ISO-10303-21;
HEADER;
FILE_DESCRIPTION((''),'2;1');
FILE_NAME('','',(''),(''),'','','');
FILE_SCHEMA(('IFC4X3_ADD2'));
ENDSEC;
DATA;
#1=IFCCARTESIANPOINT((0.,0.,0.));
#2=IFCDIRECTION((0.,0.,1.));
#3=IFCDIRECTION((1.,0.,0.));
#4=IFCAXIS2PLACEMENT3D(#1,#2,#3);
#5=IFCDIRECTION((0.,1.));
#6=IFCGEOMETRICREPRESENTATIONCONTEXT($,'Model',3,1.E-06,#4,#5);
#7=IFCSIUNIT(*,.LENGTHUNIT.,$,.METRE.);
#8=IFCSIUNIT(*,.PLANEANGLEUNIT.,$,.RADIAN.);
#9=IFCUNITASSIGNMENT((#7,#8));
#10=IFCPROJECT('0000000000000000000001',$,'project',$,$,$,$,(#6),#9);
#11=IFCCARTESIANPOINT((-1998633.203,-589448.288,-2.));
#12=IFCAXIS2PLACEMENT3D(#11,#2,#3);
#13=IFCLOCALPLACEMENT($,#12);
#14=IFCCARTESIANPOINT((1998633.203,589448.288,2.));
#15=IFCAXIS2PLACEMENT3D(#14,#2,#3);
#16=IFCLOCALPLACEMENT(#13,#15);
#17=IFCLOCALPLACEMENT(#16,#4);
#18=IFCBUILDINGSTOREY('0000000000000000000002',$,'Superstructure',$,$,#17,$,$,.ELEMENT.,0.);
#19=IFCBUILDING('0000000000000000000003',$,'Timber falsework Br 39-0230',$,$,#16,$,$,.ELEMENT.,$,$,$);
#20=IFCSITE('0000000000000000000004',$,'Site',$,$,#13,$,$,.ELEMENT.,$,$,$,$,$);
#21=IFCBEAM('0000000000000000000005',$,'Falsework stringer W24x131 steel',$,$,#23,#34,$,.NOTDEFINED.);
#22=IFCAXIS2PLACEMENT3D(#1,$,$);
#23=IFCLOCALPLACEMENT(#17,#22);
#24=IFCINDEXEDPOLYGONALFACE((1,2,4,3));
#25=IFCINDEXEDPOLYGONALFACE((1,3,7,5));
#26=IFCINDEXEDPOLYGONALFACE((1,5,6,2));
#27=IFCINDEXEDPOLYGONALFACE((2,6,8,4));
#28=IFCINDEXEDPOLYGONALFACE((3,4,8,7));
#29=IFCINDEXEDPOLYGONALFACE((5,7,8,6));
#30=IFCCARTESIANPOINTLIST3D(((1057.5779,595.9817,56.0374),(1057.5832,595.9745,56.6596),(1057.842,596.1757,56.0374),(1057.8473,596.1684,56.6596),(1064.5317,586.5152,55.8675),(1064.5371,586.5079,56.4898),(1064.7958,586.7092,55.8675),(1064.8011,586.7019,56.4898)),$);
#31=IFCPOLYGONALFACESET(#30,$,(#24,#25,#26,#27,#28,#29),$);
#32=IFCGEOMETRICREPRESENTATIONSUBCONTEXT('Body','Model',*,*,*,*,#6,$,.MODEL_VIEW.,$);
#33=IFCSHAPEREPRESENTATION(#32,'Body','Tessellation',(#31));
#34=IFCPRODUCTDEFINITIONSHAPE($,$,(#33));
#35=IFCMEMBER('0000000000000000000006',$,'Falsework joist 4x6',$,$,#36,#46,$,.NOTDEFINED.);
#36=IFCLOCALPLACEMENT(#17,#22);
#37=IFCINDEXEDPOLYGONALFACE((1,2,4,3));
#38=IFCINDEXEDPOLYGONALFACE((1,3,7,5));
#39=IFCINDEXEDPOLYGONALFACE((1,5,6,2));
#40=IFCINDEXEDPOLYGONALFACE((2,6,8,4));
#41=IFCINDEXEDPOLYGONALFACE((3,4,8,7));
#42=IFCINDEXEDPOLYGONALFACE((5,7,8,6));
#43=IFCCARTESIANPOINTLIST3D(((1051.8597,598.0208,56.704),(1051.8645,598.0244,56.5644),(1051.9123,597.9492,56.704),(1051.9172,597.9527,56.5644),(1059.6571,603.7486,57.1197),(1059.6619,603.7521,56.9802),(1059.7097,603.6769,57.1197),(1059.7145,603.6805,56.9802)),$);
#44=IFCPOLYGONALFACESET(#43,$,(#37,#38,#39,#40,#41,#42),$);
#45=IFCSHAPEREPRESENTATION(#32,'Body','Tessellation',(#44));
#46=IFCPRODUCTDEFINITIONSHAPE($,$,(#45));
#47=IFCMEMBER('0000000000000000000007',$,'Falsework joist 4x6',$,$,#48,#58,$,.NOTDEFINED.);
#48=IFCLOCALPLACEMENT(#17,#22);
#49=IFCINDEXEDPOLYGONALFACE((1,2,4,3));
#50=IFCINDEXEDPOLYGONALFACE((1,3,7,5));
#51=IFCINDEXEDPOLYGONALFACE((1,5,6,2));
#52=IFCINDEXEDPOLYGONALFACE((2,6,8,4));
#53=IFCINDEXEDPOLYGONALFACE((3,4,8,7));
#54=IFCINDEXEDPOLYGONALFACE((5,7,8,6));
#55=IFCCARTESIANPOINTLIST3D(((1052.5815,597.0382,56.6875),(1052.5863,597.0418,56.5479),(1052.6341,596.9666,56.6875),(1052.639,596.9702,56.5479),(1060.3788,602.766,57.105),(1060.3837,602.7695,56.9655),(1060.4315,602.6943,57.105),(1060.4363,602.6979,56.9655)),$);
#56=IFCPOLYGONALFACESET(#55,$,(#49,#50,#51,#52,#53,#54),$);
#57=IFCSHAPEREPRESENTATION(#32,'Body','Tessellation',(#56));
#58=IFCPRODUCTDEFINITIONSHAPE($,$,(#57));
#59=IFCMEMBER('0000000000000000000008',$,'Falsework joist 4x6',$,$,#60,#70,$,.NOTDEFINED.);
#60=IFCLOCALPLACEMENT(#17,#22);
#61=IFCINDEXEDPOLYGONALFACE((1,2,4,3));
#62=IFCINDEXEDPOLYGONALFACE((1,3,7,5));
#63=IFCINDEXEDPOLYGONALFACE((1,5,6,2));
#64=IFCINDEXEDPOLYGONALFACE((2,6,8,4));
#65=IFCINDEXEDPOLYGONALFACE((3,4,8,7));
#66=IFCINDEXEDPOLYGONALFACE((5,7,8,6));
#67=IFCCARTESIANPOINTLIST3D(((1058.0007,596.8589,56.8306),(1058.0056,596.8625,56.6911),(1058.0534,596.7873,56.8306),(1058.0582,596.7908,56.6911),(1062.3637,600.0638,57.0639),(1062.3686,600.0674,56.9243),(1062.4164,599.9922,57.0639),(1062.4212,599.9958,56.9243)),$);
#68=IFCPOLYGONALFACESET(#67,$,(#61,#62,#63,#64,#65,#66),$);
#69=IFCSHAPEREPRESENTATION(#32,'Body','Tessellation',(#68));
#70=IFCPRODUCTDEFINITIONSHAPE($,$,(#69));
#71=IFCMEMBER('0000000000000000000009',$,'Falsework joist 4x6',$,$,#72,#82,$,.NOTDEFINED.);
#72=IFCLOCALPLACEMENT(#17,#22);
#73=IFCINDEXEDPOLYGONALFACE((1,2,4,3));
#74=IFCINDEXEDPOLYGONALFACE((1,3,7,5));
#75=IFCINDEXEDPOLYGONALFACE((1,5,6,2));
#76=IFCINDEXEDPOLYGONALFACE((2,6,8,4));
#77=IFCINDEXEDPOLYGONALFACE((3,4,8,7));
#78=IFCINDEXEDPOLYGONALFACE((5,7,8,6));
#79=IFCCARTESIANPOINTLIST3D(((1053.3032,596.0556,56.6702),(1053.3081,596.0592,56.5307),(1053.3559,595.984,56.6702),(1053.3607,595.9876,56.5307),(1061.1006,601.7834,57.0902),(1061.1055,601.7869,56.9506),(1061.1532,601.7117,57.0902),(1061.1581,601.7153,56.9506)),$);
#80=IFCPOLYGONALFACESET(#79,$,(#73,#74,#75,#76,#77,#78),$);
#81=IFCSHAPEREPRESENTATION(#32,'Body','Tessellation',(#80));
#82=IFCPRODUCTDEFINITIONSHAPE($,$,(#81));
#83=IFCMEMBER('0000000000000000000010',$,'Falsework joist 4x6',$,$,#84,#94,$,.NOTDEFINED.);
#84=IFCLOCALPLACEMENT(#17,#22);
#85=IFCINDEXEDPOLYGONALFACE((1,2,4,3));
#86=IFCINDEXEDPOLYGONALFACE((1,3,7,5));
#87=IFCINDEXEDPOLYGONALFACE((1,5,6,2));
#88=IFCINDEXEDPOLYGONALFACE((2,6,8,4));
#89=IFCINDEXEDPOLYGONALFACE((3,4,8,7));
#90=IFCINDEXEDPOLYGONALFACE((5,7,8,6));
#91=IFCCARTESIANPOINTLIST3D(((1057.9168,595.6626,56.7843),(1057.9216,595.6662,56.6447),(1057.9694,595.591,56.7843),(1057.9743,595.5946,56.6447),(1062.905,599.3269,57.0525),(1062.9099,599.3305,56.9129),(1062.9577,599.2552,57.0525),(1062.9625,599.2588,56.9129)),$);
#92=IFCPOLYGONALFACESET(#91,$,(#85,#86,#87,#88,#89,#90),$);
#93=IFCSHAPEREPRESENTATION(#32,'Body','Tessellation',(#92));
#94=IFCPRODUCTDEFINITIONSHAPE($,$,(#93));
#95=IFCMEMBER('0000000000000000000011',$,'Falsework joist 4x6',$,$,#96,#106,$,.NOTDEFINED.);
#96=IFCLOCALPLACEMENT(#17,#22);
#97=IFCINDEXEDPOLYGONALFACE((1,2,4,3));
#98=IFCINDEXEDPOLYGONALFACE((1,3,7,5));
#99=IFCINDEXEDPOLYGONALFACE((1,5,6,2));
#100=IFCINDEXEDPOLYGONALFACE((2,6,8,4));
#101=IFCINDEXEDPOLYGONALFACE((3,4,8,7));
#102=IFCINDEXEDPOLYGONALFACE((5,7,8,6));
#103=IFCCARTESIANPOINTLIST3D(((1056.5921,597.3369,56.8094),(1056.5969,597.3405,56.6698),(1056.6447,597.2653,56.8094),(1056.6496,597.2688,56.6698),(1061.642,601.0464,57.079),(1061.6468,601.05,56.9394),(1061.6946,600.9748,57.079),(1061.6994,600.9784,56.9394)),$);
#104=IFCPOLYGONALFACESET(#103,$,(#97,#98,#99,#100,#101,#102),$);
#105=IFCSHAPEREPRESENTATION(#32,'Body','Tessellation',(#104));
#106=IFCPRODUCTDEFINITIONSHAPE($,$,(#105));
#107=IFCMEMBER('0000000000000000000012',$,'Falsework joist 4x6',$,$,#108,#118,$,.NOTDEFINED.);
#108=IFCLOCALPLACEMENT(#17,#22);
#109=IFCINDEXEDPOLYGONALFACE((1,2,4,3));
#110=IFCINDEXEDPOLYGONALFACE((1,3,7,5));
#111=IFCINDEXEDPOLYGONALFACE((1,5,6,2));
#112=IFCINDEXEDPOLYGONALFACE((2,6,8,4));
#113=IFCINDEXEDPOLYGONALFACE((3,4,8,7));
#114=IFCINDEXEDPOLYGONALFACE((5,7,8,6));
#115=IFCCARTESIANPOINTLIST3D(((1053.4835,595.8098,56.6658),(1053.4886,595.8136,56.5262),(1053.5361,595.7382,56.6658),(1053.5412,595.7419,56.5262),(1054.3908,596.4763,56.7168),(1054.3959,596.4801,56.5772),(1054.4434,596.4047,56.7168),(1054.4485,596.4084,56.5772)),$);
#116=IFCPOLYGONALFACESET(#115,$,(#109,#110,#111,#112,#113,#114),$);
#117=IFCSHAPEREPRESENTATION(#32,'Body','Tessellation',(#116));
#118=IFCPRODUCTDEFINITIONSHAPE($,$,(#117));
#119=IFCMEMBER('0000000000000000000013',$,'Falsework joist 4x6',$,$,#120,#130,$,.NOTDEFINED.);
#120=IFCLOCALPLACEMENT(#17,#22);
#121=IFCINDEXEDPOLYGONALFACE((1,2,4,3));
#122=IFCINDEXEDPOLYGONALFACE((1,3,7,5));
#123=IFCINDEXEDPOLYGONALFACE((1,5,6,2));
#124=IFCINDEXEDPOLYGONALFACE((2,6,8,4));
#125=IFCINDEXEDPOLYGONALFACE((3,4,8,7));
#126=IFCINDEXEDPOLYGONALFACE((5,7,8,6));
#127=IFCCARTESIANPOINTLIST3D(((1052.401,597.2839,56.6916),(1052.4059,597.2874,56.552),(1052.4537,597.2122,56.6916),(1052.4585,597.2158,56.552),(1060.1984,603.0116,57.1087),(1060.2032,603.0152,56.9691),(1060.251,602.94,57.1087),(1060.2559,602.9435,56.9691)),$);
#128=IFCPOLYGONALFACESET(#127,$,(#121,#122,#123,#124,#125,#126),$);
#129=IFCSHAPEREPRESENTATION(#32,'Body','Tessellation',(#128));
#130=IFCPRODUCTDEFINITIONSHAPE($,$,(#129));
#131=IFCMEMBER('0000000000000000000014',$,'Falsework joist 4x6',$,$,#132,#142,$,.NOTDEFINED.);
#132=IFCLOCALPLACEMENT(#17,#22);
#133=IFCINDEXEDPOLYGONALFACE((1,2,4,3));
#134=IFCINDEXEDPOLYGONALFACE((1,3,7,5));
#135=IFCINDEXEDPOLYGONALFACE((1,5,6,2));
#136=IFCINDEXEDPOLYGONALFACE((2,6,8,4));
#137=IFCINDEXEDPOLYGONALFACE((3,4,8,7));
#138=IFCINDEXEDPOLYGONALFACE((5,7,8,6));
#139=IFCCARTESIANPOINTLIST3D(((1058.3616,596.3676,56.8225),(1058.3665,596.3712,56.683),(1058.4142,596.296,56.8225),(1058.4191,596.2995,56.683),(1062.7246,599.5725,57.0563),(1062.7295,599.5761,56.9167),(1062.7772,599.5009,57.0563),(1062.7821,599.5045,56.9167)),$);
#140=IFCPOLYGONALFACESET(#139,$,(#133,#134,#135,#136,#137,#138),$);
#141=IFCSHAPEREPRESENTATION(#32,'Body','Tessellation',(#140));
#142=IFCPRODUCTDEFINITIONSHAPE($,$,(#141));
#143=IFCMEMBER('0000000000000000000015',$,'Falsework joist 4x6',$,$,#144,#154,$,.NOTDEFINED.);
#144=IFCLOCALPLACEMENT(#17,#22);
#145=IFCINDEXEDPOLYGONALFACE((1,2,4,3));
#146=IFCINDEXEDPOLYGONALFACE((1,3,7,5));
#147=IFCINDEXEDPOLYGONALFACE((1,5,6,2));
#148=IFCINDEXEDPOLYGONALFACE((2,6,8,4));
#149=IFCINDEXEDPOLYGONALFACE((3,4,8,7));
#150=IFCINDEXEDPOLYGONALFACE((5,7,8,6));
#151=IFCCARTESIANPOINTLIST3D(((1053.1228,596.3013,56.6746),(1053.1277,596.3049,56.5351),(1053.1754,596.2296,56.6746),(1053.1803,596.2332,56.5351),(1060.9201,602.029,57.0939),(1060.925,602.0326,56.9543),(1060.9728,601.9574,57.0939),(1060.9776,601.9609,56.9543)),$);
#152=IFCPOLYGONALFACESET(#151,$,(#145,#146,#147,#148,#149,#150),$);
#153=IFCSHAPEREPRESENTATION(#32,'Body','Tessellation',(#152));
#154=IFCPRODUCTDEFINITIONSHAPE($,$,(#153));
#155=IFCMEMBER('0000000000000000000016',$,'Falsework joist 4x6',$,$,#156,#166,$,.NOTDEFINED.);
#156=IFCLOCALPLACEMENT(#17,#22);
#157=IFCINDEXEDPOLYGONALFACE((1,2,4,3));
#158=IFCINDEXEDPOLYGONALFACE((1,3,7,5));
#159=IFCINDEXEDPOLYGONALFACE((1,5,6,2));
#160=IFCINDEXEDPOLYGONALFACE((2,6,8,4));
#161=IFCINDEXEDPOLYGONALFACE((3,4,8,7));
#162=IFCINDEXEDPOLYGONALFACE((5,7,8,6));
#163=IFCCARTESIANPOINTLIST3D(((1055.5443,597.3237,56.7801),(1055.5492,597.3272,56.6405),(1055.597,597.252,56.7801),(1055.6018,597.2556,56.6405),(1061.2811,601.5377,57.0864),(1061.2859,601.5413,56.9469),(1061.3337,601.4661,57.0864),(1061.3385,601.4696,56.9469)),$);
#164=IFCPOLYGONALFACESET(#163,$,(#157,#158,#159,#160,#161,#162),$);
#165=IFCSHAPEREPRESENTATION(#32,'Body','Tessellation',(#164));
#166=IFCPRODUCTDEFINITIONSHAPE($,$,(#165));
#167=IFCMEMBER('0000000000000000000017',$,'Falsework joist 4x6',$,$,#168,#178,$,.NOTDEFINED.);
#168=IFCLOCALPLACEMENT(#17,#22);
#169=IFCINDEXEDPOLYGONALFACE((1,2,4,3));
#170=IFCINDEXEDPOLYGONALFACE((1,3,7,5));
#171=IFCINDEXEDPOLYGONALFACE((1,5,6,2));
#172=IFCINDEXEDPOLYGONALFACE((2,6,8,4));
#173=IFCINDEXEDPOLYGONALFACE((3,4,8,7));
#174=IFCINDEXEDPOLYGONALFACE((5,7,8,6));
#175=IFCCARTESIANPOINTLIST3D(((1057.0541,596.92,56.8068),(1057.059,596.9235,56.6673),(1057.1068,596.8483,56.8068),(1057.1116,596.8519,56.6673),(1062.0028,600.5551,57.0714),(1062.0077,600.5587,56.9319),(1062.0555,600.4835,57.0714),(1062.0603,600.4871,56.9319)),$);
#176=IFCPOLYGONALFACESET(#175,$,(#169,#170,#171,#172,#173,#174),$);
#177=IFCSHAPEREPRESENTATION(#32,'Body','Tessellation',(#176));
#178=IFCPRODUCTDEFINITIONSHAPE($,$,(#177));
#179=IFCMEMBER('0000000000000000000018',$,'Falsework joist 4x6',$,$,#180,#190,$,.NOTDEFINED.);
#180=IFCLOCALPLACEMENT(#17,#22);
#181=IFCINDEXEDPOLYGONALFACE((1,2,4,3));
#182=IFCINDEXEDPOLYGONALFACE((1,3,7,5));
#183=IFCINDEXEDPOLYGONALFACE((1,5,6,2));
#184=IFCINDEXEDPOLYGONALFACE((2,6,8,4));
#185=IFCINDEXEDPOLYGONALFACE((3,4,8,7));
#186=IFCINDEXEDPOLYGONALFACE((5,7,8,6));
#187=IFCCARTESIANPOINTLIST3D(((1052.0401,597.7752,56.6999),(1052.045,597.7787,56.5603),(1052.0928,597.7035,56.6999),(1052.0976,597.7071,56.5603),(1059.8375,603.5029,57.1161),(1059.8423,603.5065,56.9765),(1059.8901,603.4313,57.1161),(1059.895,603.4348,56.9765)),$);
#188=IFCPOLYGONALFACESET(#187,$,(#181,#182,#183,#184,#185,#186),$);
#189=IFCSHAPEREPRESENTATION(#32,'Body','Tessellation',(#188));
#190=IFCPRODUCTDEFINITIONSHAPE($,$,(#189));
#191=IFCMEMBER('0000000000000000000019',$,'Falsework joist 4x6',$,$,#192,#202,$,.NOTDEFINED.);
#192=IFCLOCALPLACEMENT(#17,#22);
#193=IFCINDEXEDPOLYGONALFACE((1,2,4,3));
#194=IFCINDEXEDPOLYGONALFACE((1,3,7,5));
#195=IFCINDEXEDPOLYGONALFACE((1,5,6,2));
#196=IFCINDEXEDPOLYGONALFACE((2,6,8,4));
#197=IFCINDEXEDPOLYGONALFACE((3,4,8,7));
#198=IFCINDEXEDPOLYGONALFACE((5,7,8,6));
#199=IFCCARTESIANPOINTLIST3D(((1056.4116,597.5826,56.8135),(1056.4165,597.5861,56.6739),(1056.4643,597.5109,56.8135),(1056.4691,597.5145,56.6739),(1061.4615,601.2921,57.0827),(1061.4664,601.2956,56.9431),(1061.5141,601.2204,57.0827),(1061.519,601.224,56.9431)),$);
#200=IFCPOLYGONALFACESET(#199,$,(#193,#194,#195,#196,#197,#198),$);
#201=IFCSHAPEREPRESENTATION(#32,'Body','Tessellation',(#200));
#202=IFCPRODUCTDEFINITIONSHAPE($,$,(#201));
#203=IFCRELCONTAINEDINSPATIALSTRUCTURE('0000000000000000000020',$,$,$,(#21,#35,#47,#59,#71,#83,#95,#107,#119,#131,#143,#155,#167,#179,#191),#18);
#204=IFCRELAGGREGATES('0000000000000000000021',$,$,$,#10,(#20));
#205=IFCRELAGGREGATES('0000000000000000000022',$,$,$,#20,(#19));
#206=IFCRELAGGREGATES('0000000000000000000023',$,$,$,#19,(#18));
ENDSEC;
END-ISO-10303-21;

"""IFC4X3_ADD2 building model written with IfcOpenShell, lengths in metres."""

from ifc_helpers import new_model, si_unit, direction, frame, frame_2d, origin, origin_with_axes, place, context, subcontext, project, spatial, rectangle, extrude, element, save


model = new_model("IFC4X3_ADD2")

# Units and contexts
model_context = context("Model", 3, precision=1e-06, world=origin_with_axes(), true_north=direction((0.0, 1.0)))
body_context = subcontext(model_context, "Body", "Model", "MODEL_VIEW")
ifc_project = project(units=[si_unit("LENGTHUNIT", "METRE"), si_unit("PLANEANGLEUNIT", "RADIAN")], contexts=[model_context])

# Site, building, storey
site_placement = place(None, frame((-1998633.203, -589448.288, -2.0), z_axis=(0.0, 0.0, 1.0), x_axis=(1.0, 0.0, 0.0)))
site = spatial("IfcSite", under=ifc_project, at=site_placement, Name="Site", CompositionType="ELEMENT")
building_placement = place(site_placement, frame((1998633.203, 589448.288, 2.0), z_axis=(0.0, 0.0, 1.0), x_axis=(1.0, 0.0, 0.0)))
building = spatial("IfcBuilding", under=site, at=building_placement, Name="Timber falsework Br 39-0230", CompositionType="ELEMENT")
storey_placement = place(building_placement, origin_with_axes())
storey = spatial("IfcBuildingStorey", under=building, at=storey_placement, Name="Superstructure", CompositionType="ELEMENT", Elevation=0.0)

# Beam
beam_placement = place(storey_placement, frame((1057.7099, 596.0787, 56.0374), z_axis=(0.591951, -0.805844, -0.01446), x_axis=(0.805928, 0.592013, 0.0)))
element("IfcBeam", 1, at=beam_placement, inside=storey, Name="Falsework stringer W24x131 steel", PredefinedType="NOTDEFINED", context=body_context, shape_type="SweptSolid", body=[
    extrude(rectangle(XDim=0.3277, YDim=0.6223, at=frame_2d((0.0, 0.3111))), origin(), (0.0, 0.0, 1.0), 11.7473),
])

# Members
member_1_placement = place(storey_placement, frame((1051.8909, 597.9886, 56.5644), z_axis=(0.805185, 0.591467, 0.042932), x_axis=(-0.592013, 0.805928, 0.0)))
element("IfcMember", 2, at=member_1_placement, inside=storey, Name="Falsework joist 4x6", PredefinedType="NOTDEFINED", context=body_context, shape_type="SweptSolid", body=[
    extrude(rectangle(XDim=0.0889, YDim=0.1397, at=frame_2d((0.0, 0.0698))), origin(), (0.0, 0.0, 1.0), 9.6839),
])
member_2_placement = place(storey_placement, frame((1052.6126, 597.006, 56.5479), z_axis=(0.805179, 0.591463, 0.043119), x_axis=(-0.592013, 0.805928, 0.0)))
element("IfcMember", 3, at=member_2_placement, inside=storey, Name="Falsework joist 4x6", PredefinedType="NOTDEFINED", context=body_context, shape_type="SweptSolid", body=[
    extrude(rectangle(XDim=0.0889, YDim=0.1397, at=frame_2d((0.0, 0.0698))), origin(), (0.0, 0.0, 1.0), 9.684),
])
member_3_placement = place(storey_placement, frame((1058.0319, 596.8266, 56.6911), z_axis=(0.805181, 0.591464, 0.043046), x_axis=(-0.592013, 0.805928, 0.0)))
element("IfcMember", 4, at=member_3_placement, inside=storey, Name="Falsework joist 4x6", PredefinedType="NOTDEFINED", context=body_context, shape_type="SweptSolid", body=[
    extrude(rectangle(XDim=0.0889, YDim=0.1397, at=frame_2d((0.0, 0.0698))), origin(), (0.0, 0.0, 1.0), 5.4187),
])
member_4_placement = place(storey_placement, frame((1053.3344, 596.0234, 56.5307), z_axis=(0.80517, 0.591456, 0.043365), x_axis=(-0.592013, 0.805928, 0.0)))
element("IfcMember", 5, at=member_4_placement, inside=storey, Name="Falsework joist 4x6", PredefinedType="NOTDEFINED", context=body_context, shape_type="SweptSolid", body=[
    extrude(rectangle(XDim=0.0889, YDim=0.1397, at=frame_2d((0.0, 0.0698))), origin(), (0.0, 0.0, 1.0), 9.6841),
])
member_5_placement = place(storey_placement, frame((1057.948, 595.6304, 56.6447), z_axis=(0.805173, 0.591458, 0.043294), x_axis=(-0.592013, 0.805928, 0.0)))
element("IfcMember", 6, at=member_5_placement, inside=storey, Name="Falsework joist 4x6", PredefinedType="NOTDEFINED", context=body_context, shape_type="SweptSolid", body=[
    extrude(rectangle(XDim=0.0889, YDim=0.1397, at=frame_2d((0.0, 0.0698))), origin(), (0.0, 0.0, 1.0), 6.1953),
])
member_6_placement = place(storey_placement, frame((1056.6232, 597.3047, 56.6698), z_axis=(0.805184, 0.591466, 0.042976), x_axis=(-0.592013, 0.805928, 0.0)))
element("IfcMember", 7, at=member_6_placement, inside=storey, Name="Falsework joist 4x6", PredefinedType="NOTDEFINED", context=body_context, shape_type="SweptSolid", body=[
    extrude(rectangle(XDim=0.0889, YDim=0.1397, at=frame_2d((0.0, 0.0698))), origin(), (0.0, 0.0, 1.0), 6.2717),
])
member_7_placement = place(storey_placement, frame((1053.5149, 595.7777, 56.5262), z_axis=(0.805103, 0.591407, 0.045231), x_axis=(-0.592013, 0.805928, 0.0)))
element("IfcMember", 8, at=member_7_placement, inside=storey, Name="Falsework joist 4x6", PredefinedType="NOTDEFINED", context=body_context, shape_type="SweptSolid", body=[
    extrude(rectangle(XDim=0.0889, YDim=0.1397, at=frame_2d((0.0, 0.0698))), origin(), (0.0, 0.0, 1.0), 1.127),
])
member_8_placement = place(storey_placement, frame((1052.4322, 597.2516, 56.552), z_axis=(0.80518, 0.591464, 0.043073), x_axis=(-0.592013, 0.805928, 0.0)))
element("IfcMember", 9, at=member_8_placement, inside=storey, Name="Falsework joist 4x6", PredefinedType="NOTDEFINED", context=body_context, shape_type="SweptSolid", body=[
    extrude(rectangle(XDim=0.0889, YDim=0.1397, at=frame_2d((0.0, 0.0698))), origin(), (0.0, 0.0, 1.0), 9.684),
])
member_9_placement = place(storey_placement, frame((1058.3928, 596.3353, 56.683), z_axis=(0.805178, 0.591462, 0.043139), x_axis=(-0.592013, 0.805928, 0.0)))
element("IfcMember", 10, at=member_9_placement, inside=storey, Name="Falsework joist 4x6", PredefinedType="NOTDEFINED", context=body_context, shape_type="SweptSolid", body=[
    extrude(rectangle(XDim=0.0889, YDim=0.1397, at=frame_2d((0.0, 0.0698))), origin(), (0.0, 0.0, 1.0), 5.4187),
])
member_10_placement = place(storey_placement, frame((1053.154, 596.269, 56.5351), z_axis=(0.805173, 0.591458, 0.043295), x_axis=(-0.592013, 0.805928, 0.0)))
element("IfcMember", 11, at=member_10_placement, inside=storey, Name="Falsework joist 4x6", PredefinedType="NOTDEFINED", context=body_context, shape_type="SweptSolid", body=[
    extrude(rectangle(XDim=0.0889, YDim=0.1397, at=frame_2d((0.0, 0.0698))), origin(), (0.0, 0.0, 1.0), 9.6841),
])
member_11_placement = place(storey_placement, frame((1055.5755, 597.2914, 56.6405), z_axis=(0.805183, 0.591466, 0.043), x_axis=(-0.592013, 0.805928, 0.0)))
element("IfcMember", 12, at=member_11_placement, inside=storey, Name="Falsework joist 4x6", PredefinedType="NOTDEFINED", context=body_context, shape_type="SweptSolid", body=[
    extrude(rectangle(XDim=0.0889, YDim=0.1397, at=frame_2d((0.0, 0.0698))), origin(), (0.0, 0.0, 1.0), 7.1248),
])
member_12_placement = place(storey_placement, frame((1057.0853, 596.8877, 56.6673), z_axis=(0.805181, 0.591464, 0.043052), x_axis=(-0.592013, 0.805928, 0.0)))
element("IfcMember", 13, at=member_12_placement, inside=storey, Name="Falsework joist 4x6", PredefinedType="NOTDEFINED", context=body_context, shape_type="SweptSolid", body=[
    extrude(rectangle(XDim=0.0889, YDim=0.1397, at=frame_2d((0.0, 0.0698))), origin(), (0.0, 0.0, 1.0), 6.1461),
])
member_13_placement = place(storey_placement, frame((1052.0713, 597.7429, 56.5603), z_axis=(0.805184, 0.591466, 0.042979), x_axis=(-0.592013, 0.805928, 0.0)))
element("IfcMember", 14, at=member_13_placement, inside=storey, Name="Falsework joist 4x6", PredefinedType="NOTDEFINED", context=body_context, shape_type="SweptSolid", body=[
    extrude(rectangle(XDim=0.0889, YDim=0.1397, at=frame_2d((0.0, 0.0698))), origin(), (0.0, 0.0, 1.0), 9.6839),
])
member_14_placement = place(storey_placement, frame((1056.4428, 597.5503, 56.6739), z_axis=(0.805185, 0.591467, 0.042929), x_axis=(-0.592013, 0.805928, 0.0)))
element("IfcMember", 15, at=member_14_placement, inside=storey, Name="Falsework joist 4x6", PredefinedType="NOTDEFINED", context=body_context, shape_type="SweptSolid", body=[
    extrude(rectangle(XDim=0.0889, YDim=0.1397, at=frame_2d((0.0, 0.0698))), origin(), (0.0, 0.0, 1.0), 6.2717),
])

save(model, "model.ifc")
